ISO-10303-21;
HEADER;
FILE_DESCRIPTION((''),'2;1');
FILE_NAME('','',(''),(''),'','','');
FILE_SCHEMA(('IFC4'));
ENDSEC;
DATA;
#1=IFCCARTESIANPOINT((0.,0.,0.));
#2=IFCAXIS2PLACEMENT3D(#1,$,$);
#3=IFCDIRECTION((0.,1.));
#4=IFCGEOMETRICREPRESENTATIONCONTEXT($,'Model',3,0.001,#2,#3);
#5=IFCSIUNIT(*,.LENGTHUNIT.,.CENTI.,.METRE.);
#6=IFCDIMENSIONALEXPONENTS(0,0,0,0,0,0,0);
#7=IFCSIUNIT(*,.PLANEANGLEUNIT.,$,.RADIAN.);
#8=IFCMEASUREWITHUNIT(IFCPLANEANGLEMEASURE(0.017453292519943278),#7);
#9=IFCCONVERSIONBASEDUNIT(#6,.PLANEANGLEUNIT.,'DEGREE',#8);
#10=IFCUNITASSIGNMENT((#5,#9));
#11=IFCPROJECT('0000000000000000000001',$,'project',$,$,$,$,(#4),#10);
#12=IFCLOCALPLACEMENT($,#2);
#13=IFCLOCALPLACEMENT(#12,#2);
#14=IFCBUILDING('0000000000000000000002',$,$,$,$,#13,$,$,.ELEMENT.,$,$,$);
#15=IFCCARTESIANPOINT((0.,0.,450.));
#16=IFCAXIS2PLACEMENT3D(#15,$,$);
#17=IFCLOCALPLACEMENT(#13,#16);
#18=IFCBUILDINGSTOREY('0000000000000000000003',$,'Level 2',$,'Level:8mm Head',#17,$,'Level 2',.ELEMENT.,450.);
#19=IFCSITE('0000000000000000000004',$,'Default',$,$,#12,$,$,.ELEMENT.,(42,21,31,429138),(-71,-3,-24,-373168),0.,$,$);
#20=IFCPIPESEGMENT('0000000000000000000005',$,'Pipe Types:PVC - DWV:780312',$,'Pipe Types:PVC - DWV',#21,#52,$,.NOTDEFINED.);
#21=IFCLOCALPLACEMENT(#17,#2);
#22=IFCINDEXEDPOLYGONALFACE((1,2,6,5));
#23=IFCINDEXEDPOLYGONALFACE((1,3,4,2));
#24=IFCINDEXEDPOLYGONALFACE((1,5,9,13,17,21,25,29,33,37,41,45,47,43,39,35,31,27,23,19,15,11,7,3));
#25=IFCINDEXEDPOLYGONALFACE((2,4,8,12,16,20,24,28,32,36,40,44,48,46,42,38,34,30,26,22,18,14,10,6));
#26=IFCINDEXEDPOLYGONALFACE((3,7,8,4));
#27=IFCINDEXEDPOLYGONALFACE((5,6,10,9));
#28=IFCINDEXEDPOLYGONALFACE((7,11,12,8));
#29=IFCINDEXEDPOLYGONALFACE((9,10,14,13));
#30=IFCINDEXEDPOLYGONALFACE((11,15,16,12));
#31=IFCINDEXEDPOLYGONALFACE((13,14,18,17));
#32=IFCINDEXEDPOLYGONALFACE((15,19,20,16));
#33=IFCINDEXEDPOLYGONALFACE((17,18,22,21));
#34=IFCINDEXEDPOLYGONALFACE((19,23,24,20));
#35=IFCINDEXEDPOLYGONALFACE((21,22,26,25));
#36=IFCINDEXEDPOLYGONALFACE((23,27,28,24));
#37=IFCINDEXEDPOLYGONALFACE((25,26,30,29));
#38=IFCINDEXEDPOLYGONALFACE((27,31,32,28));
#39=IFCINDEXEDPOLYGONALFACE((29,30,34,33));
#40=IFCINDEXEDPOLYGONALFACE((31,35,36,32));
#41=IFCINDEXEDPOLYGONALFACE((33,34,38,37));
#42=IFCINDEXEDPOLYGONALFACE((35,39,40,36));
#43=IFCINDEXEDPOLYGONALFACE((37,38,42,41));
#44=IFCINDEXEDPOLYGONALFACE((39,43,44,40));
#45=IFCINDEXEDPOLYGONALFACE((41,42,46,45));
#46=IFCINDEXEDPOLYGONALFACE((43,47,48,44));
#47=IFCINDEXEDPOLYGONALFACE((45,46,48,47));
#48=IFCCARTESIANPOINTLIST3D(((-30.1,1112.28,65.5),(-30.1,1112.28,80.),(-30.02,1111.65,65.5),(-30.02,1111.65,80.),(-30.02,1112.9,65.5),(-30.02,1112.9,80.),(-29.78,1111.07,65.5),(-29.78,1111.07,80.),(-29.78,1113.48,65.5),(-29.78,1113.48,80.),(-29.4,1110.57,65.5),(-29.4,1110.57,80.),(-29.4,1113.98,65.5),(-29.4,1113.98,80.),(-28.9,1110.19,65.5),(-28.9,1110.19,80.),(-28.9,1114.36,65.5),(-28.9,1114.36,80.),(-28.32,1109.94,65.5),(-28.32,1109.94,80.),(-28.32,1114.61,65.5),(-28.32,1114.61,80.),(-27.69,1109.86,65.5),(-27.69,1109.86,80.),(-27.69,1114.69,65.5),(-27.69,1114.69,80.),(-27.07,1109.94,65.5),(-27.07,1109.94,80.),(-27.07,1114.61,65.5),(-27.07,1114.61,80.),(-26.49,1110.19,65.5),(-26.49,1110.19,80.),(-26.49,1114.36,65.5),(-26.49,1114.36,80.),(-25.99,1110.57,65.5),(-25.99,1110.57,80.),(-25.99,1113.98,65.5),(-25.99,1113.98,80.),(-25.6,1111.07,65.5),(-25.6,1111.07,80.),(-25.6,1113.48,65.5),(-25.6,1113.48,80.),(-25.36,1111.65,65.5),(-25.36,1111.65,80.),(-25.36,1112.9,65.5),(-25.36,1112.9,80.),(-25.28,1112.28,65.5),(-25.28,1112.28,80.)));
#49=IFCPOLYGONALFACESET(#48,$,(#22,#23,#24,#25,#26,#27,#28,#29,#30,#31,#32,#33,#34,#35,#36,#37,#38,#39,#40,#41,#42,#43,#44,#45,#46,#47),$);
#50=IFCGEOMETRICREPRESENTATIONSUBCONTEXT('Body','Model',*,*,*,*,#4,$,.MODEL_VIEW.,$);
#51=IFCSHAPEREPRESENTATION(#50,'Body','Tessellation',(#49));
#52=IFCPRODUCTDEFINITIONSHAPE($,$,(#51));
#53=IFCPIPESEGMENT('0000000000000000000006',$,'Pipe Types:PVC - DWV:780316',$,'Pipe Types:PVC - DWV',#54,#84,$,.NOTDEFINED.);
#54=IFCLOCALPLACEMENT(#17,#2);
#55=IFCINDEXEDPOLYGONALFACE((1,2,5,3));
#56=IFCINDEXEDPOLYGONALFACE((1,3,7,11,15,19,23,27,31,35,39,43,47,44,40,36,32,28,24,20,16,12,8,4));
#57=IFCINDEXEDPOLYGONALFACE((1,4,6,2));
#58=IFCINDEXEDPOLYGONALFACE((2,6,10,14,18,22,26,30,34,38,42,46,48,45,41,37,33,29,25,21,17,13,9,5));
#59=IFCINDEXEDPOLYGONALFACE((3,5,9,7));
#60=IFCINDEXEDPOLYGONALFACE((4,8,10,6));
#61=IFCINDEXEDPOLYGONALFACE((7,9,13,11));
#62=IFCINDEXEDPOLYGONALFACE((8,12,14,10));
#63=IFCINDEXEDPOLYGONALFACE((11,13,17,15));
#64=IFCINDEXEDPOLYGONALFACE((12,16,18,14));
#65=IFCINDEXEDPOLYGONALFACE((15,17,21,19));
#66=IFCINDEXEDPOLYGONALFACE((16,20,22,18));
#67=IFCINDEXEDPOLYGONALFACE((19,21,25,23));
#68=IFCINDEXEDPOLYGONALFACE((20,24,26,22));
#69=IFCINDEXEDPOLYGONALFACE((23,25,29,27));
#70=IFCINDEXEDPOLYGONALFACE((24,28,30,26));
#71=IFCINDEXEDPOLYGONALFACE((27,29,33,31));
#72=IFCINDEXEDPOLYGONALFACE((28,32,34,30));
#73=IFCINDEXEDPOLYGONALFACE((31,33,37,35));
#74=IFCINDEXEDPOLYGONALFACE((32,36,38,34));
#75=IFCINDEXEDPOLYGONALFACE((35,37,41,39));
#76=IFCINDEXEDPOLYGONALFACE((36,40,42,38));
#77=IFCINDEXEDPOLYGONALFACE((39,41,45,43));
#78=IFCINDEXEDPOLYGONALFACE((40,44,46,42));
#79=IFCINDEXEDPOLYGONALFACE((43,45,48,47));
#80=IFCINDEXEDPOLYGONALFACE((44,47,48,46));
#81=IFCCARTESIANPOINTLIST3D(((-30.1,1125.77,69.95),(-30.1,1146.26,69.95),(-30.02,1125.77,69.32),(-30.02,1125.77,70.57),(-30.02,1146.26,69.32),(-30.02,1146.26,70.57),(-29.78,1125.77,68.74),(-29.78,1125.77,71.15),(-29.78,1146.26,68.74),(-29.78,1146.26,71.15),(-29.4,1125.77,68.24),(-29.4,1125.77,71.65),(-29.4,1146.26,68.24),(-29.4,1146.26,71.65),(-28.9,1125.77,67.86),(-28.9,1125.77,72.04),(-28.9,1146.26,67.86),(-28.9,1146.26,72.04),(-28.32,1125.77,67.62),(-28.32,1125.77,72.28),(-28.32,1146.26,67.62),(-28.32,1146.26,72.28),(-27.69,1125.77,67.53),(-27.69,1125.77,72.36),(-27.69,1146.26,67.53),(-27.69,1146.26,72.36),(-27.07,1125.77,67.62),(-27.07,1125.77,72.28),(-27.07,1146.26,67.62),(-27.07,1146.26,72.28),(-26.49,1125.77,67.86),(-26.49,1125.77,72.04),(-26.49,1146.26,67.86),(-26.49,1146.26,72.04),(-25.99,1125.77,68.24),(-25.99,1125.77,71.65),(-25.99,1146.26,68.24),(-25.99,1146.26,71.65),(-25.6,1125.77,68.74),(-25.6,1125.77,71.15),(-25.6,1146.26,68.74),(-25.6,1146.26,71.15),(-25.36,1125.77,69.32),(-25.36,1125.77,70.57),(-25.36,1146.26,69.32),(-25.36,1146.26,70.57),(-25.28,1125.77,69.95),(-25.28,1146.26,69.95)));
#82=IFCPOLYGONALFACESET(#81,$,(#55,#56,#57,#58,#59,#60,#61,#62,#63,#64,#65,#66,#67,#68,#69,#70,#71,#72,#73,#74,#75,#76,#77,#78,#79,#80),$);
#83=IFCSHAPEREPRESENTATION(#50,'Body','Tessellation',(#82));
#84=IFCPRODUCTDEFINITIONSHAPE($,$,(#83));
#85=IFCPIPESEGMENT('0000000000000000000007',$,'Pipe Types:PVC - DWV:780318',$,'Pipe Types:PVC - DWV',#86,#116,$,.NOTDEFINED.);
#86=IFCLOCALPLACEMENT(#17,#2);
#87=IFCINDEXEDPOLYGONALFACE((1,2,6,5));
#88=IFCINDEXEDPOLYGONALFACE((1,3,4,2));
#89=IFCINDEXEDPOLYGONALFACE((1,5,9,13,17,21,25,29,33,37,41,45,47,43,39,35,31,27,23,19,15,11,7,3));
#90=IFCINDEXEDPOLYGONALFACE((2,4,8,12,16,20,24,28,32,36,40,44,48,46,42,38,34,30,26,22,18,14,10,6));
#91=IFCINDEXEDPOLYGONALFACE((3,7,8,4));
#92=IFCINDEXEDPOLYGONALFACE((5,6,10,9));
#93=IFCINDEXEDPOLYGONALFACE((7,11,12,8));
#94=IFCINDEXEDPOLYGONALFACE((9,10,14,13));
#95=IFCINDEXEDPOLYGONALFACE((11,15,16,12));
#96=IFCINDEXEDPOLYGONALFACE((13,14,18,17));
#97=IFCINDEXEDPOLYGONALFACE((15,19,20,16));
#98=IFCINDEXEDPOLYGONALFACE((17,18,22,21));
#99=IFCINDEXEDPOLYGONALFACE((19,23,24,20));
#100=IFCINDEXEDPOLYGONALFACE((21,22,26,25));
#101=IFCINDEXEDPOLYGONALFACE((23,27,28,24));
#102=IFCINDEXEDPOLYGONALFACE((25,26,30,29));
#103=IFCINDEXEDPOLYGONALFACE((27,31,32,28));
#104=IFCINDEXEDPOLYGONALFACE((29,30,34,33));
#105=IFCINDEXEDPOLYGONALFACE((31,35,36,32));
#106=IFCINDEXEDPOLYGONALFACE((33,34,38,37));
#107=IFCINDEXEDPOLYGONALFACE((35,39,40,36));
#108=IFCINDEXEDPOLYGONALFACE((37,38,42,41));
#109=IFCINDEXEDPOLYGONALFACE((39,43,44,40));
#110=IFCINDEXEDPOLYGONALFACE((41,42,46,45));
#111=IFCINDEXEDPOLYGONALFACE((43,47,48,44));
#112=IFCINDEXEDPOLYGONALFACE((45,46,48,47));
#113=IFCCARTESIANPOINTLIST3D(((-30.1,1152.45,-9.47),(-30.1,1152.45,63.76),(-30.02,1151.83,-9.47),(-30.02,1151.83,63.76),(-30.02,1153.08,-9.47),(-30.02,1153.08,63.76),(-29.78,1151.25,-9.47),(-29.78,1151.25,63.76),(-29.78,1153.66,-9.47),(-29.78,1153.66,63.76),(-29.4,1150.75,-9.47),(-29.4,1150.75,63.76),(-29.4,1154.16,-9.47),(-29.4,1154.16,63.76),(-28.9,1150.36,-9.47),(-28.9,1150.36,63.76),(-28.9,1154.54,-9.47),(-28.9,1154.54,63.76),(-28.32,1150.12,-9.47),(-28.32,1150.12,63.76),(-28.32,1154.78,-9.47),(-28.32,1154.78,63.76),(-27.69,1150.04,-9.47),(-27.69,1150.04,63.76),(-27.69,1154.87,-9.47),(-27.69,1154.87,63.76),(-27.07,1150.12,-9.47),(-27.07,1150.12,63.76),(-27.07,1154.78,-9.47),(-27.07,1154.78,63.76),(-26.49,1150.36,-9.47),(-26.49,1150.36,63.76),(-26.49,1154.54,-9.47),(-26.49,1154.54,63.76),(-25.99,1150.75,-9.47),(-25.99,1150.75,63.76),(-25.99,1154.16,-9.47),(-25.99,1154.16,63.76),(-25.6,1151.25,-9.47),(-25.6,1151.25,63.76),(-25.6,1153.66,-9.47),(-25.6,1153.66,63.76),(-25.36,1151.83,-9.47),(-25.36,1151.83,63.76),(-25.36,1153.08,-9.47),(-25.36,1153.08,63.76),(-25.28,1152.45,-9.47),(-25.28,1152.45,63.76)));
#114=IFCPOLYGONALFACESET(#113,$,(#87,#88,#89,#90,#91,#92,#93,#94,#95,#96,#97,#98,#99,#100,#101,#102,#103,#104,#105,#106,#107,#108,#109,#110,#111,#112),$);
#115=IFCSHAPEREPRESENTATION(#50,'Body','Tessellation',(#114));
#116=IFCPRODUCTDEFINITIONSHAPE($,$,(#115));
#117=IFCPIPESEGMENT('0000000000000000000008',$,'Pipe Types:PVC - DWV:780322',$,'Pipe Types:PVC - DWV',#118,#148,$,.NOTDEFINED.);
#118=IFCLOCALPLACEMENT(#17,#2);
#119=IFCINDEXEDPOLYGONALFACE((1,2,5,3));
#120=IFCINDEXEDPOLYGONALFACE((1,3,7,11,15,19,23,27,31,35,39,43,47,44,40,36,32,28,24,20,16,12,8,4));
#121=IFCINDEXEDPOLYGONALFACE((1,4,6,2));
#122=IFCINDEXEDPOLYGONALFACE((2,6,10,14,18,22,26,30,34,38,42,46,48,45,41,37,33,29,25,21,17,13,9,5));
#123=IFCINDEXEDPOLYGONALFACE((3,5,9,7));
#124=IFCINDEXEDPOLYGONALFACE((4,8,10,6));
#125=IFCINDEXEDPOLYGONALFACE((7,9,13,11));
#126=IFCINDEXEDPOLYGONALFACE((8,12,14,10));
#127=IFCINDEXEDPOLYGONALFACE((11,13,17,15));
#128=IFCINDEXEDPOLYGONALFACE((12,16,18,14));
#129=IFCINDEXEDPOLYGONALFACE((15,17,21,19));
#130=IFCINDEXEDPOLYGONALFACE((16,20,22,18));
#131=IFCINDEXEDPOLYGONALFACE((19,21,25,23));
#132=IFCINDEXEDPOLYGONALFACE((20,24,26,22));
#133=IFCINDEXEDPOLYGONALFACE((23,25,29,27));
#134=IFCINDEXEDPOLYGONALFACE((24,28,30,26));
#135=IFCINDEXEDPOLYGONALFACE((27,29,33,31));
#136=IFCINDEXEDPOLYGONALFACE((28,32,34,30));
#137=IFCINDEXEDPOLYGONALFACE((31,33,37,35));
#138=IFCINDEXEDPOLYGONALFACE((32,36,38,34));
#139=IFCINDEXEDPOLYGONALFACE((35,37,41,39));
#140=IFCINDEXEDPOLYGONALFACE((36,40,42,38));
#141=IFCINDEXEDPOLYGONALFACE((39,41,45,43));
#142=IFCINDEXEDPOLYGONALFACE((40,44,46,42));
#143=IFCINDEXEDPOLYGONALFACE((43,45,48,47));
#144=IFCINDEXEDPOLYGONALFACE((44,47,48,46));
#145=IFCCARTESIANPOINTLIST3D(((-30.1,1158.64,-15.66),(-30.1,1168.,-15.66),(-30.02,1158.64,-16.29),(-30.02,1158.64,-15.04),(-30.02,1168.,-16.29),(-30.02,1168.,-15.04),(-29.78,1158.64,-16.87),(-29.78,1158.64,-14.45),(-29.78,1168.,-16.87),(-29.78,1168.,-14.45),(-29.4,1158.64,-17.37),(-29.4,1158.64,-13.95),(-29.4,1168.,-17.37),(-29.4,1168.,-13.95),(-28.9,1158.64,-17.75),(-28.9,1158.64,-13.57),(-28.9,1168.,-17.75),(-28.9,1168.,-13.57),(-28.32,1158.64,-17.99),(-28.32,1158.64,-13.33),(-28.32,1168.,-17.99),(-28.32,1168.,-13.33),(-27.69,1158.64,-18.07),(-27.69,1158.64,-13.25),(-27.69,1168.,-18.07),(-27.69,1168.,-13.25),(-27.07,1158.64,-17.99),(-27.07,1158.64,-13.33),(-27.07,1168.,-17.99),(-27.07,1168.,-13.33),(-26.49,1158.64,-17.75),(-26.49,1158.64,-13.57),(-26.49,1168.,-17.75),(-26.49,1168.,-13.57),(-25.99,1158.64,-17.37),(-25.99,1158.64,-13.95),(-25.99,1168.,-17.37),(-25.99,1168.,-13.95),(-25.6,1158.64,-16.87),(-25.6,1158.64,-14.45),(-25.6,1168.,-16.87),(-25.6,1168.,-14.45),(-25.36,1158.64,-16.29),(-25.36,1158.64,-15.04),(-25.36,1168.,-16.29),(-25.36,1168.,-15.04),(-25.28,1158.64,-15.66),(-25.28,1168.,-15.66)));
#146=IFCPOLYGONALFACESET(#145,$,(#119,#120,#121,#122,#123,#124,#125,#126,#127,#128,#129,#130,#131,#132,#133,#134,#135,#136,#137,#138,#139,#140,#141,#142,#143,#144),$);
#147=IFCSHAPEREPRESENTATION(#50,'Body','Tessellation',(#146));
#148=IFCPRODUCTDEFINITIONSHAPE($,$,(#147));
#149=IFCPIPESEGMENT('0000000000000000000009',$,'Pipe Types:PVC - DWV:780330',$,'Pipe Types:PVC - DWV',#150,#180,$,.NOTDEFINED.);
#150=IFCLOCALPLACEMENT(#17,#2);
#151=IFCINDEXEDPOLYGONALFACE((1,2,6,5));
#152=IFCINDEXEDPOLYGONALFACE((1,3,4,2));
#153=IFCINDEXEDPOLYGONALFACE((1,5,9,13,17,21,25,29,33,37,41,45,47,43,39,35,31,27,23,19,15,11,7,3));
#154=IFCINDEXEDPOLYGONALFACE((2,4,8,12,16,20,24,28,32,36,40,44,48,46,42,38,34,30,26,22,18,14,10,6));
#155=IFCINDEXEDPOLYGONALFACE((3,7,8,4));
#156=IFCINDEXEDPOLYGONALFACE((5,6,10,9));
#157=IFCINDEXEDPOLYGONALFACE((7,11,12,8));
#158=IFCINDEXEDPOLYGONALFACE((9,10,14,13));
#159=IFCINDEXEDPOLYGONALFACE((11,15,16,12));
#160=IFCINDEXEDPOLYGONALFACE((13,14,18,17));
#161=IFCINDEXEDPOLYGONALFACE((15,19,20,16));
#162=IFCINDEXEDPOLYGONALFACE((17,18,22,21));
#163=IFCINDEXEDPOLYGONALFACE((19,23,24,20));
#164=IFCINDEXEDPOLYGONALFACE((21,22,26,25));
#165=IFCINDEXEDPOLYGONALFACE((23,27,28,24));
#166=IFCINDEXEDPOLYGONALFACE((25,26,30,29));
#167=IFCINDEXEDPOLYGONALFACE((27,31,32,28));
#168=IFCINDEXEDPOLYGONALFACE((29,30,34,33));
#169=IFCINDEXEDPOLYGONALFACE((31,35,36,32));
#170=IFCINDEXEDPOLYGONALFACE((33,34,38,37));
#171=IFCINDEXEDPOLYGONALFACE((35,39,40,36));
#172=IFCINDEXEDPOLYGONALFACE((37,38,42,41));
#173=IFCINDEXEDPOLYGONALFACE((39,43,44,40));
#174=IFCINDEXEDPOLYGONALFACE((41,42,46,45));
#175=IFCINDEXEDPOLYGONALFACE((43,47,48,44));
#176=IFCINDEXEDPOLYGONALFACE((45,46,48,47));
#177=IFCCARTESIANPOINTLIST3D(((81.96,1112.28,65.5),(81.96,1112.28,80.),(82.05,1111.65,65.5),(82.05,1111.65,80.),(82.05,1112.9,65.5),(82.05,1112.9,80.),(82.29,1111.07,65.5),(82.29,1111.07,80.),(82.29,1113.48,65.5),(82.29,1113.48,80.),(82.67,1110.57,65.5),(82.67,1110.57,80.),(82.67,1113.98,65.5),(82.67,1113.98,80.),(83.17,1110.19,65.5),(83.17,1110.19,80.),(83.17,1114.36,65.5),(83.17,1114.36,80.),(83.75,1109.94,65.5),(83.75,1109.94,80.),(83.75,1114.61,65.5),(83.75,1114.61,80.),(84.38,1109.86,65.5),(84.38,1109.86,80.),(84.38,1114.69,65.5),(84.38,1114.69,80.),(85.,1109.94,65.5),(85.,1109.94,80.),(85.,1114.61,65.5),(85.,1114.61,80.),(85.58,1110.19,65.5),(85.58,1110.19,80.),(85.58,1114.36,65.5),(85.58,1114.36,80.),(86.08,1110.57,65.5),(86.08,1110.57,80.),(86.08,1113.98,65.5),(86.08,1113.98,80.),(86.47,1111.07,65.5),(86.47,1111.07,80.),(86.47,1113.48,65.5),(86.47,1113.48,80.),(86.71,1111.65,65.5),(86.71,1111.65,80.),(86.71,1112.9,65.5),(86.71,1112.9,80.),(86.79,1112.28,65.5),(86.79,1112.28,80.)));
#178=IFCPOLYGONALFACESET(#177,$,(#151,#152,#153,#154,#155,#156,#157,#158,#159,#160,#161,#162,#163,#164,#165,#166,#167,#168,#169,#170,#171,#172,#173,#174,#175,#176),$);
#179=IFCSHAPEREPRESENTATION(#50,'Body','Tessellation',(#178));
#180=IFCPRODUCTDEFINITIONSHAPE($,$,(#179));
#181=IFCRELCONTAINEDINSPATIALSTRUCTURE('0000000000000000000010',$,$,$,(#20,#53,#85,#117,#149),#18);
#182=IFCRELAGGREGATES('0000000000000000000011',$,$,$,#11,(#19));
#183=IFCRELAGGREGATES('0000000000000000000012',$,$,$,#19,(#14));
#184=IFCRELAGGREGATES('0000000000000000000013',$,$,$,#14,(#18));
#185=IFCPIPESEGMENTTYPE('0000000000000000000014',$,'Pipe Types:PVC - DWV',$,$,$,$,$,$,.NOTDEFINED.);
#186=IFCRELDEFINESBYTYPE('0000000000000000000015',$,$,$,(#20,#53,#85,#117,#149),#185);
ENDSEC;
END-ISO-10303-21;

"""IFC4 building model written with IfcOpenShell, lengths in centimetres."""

from ifc_helpers import new_model, entity, si_unit, converted_unit, direction, frame, origin, place, context, subcontext, project, spatial, arc, indexed_curve, outline, extrude, type_object, element, save


model = new_model("IFC4")

# Units and contexts
model_context = context("Model", 3, precision=0.001, world=origin(), true_north=direction((0.0, 1.0)))
body_context = subcontext(model_context, "Body", "Model", "MODEL_VIEW")
ifc_project = project(units=[si_unit("LENGTHUNIT", "METRE", prefix="CENTI"), converted_unit("PLANEANGLEUNIT", "DEGREE", entity("IfcPlaneAngleMeasure", 0.017453292519943278), si_unit("PLANEANGLEUNIT", "RADIAN"), dimensions=[0, 0, 0, 0, 0, 0, 0])], contexts=[model_context])

# Site, building, storey
site_placement = place(None, origin())
site = spatial("IfcSite", under=ifc_project, at=site_placement, Name="Default", CompositionType="ELEMENT", RefLatitude=(42, 21, 31, 429138), RefLongitude=(-71, -3, -24, -373168), RefElevation=0.0)
building_placement = place(site_placement, origin())
building = spatial("IfcBuilding", under=site, at=building_placement, CompositionType="ELEMENT")
storey_placement = place(building_placement, frame((0.0, 0.0, 450.0)))
storey = spatial("IfcBuildingStorey", under=building, at=storey_placement, Name="Level 2", ObjectType="Level:8mm Head", LongName="Level 2", CompositionType="ELEMENT", Elevation=450.0)

# Pipe segments
pipe_segment_type = type_object("IfcPipeSegmentType", Name="Pipe Types:PVC - DWV", PredefinedType="NOTDEFINED")
pipe_segment_1_placement = place(storey_placement, origin())
element("IfcPipeSegment", 1, at=pipe_segment_1_placement, inside=storey, type_object=pipe_segment_type, Name="Pipe Types:PVC - DWV:780312", ObjectType="Pipe Types:PVC - DWV", PredefinedType="NOTDEFINED", context=body_context, shape_type="SweptSolid", body=[
    extrude(outline(indexed_curve([(2.41, 0.0), (1.71, 1.71), (0.0, 2.41), (-1.71, 1.71), (-2.41, 0.0), (-1.71, -1.71), (0.0, -2.41), (1.71, -1.71)], segments=[arc(1, 2, 3), arc(3, 4, 5), arc(5, 6, 7), arc(7, 8, 1)], self_intersect=False)), frame((-27.69, 1112.28, 65.5)), (0.0, 0.0, 1.0), 14.5),
])
pipe_segment_2_placement = place(storey_placement, origin())
element("IfcPipeSegment", 2, at=pipe_segment_2_placement, inside=storey, type_object=pipe_segment_type, Name="Pipe Types:PVC - DWV:780316", ObjectType="Pipe Types:PVC - DWV", PredefinedType="NOTDEFINED", context=body_context, shape_type="SweptSolid", body=[
    extrude(outline(indexed_curve([(2.41, 0.0), (1.71, 1.71), (0.0, 2.41), (-1.71, 1.71), (-2.41, 0.0), (-1.71, -1.71), (0.0, -2.41), (1.71, -1.71)], segments=[arc(1, 2, 3), arc(3, 4, 5), arc(5, 6, 7), arc(7, 8, 1)], self_intersect=False)), frame((-27.69, 1125.77, 69.95), z_axis=(0.0, 1.0, 0.0), x_axis=(1.0, 0.0, 0.0)), (0.0, 0.0, 1.0), 20.5),
])
pipe_segment_3_placement = place(storey_placement, origin())
element("IfcPipeSegment", 3, at=pipe_segment_3_placement, inside=storey, type_object=pipe_segment_type, Name="Pipe Types:PVC - DWV:780318", ObjectType="Pipe Types:PVC - DWV", PredefinedType="NOTDEFINED", context=body_context, shape_type="SweptSolid", body=[
    extrude(outline(indexed_curve([(2.41, 0.0), (1.71, 1.71), (0.0, 2.41), (-1.71, 1.71), (-2.41, 0.0), (-1.71, -1.71), (0.0, -2.41), (1.71, -1.71)], segments=[arc(1, 2, 3), arc(3, 4, 5), arc(5, 6, 7), arc(7, 8, 1)], self_intersect=False)), frame((-27.69, 1152.45, -9.47)), (0.0, 0.0, 1.0), 73.23),
])
pipe_segment_4_placement = place(storey_placement, origin())
element("IfcPipeSegment", 4, at=pipe_segment_4_placement, inside=storey, type_object=pipe_segment_type, Name="Pipe Types:PVC - DWV:780322", ObjectType="Pipe Types:PVC - DWV", PredefinedType="NOTDEFINED", context=body_context, shape_type="SweptSolid", body=[
    extrude(outline(indexed_curve([(2.41, 0.0), (1.71, 1.71), (0.0, 2.41), (-1.71, 1.71), (-2.41, 0.0), (-1.71, -1.71), (0.0, -2.41), (1.71, -1.71)], segments=[arc(1, 2, 3), arc(3, 4, 5), arc(5, 6, 7), arc(7, 8, 1)], self_intersect=False)), frame((-27.69, 1158.64, -15.66), z_axis=(0.0, 1.0, 0.0), x_axis=(1.0, 0.0, 0.0)), (0.0, 0.0, 1.0), 9.36),
])
pipe_segment_5_placement = place(storey_placement, origin())
element("IfcPipeSegment", 5, at=pipe_segment_5_placement, inside=storey, type_object=pipe_segment_type, Name="Pipe Types:PVC - DWV:780330", ObjectType="Pipe Types:PVC - DWV", PredefinedType="NOTDEFINED", context=body_context, shape_type="SweptSolid", body=[
    extrude(outline(indexed_curve([(2.41, 0.0), (1.71, 1.71), (0.0, 2.41), (-1.71, 1.71), (-2.41, 0.0), (-1.71, -1.71), (0.0, -2.41), (1.71, -1.71)], segments=[arc(1, 2, 3), arc(3, 4, 5), arc(5, 6, 7), arc(7, 8, 1)], self_intersect=False)), frame((84.38, 1112.28, 65.5)), (0.0, 0.0, 1.0), 14.5),
])

save(model, "model.ifc")
